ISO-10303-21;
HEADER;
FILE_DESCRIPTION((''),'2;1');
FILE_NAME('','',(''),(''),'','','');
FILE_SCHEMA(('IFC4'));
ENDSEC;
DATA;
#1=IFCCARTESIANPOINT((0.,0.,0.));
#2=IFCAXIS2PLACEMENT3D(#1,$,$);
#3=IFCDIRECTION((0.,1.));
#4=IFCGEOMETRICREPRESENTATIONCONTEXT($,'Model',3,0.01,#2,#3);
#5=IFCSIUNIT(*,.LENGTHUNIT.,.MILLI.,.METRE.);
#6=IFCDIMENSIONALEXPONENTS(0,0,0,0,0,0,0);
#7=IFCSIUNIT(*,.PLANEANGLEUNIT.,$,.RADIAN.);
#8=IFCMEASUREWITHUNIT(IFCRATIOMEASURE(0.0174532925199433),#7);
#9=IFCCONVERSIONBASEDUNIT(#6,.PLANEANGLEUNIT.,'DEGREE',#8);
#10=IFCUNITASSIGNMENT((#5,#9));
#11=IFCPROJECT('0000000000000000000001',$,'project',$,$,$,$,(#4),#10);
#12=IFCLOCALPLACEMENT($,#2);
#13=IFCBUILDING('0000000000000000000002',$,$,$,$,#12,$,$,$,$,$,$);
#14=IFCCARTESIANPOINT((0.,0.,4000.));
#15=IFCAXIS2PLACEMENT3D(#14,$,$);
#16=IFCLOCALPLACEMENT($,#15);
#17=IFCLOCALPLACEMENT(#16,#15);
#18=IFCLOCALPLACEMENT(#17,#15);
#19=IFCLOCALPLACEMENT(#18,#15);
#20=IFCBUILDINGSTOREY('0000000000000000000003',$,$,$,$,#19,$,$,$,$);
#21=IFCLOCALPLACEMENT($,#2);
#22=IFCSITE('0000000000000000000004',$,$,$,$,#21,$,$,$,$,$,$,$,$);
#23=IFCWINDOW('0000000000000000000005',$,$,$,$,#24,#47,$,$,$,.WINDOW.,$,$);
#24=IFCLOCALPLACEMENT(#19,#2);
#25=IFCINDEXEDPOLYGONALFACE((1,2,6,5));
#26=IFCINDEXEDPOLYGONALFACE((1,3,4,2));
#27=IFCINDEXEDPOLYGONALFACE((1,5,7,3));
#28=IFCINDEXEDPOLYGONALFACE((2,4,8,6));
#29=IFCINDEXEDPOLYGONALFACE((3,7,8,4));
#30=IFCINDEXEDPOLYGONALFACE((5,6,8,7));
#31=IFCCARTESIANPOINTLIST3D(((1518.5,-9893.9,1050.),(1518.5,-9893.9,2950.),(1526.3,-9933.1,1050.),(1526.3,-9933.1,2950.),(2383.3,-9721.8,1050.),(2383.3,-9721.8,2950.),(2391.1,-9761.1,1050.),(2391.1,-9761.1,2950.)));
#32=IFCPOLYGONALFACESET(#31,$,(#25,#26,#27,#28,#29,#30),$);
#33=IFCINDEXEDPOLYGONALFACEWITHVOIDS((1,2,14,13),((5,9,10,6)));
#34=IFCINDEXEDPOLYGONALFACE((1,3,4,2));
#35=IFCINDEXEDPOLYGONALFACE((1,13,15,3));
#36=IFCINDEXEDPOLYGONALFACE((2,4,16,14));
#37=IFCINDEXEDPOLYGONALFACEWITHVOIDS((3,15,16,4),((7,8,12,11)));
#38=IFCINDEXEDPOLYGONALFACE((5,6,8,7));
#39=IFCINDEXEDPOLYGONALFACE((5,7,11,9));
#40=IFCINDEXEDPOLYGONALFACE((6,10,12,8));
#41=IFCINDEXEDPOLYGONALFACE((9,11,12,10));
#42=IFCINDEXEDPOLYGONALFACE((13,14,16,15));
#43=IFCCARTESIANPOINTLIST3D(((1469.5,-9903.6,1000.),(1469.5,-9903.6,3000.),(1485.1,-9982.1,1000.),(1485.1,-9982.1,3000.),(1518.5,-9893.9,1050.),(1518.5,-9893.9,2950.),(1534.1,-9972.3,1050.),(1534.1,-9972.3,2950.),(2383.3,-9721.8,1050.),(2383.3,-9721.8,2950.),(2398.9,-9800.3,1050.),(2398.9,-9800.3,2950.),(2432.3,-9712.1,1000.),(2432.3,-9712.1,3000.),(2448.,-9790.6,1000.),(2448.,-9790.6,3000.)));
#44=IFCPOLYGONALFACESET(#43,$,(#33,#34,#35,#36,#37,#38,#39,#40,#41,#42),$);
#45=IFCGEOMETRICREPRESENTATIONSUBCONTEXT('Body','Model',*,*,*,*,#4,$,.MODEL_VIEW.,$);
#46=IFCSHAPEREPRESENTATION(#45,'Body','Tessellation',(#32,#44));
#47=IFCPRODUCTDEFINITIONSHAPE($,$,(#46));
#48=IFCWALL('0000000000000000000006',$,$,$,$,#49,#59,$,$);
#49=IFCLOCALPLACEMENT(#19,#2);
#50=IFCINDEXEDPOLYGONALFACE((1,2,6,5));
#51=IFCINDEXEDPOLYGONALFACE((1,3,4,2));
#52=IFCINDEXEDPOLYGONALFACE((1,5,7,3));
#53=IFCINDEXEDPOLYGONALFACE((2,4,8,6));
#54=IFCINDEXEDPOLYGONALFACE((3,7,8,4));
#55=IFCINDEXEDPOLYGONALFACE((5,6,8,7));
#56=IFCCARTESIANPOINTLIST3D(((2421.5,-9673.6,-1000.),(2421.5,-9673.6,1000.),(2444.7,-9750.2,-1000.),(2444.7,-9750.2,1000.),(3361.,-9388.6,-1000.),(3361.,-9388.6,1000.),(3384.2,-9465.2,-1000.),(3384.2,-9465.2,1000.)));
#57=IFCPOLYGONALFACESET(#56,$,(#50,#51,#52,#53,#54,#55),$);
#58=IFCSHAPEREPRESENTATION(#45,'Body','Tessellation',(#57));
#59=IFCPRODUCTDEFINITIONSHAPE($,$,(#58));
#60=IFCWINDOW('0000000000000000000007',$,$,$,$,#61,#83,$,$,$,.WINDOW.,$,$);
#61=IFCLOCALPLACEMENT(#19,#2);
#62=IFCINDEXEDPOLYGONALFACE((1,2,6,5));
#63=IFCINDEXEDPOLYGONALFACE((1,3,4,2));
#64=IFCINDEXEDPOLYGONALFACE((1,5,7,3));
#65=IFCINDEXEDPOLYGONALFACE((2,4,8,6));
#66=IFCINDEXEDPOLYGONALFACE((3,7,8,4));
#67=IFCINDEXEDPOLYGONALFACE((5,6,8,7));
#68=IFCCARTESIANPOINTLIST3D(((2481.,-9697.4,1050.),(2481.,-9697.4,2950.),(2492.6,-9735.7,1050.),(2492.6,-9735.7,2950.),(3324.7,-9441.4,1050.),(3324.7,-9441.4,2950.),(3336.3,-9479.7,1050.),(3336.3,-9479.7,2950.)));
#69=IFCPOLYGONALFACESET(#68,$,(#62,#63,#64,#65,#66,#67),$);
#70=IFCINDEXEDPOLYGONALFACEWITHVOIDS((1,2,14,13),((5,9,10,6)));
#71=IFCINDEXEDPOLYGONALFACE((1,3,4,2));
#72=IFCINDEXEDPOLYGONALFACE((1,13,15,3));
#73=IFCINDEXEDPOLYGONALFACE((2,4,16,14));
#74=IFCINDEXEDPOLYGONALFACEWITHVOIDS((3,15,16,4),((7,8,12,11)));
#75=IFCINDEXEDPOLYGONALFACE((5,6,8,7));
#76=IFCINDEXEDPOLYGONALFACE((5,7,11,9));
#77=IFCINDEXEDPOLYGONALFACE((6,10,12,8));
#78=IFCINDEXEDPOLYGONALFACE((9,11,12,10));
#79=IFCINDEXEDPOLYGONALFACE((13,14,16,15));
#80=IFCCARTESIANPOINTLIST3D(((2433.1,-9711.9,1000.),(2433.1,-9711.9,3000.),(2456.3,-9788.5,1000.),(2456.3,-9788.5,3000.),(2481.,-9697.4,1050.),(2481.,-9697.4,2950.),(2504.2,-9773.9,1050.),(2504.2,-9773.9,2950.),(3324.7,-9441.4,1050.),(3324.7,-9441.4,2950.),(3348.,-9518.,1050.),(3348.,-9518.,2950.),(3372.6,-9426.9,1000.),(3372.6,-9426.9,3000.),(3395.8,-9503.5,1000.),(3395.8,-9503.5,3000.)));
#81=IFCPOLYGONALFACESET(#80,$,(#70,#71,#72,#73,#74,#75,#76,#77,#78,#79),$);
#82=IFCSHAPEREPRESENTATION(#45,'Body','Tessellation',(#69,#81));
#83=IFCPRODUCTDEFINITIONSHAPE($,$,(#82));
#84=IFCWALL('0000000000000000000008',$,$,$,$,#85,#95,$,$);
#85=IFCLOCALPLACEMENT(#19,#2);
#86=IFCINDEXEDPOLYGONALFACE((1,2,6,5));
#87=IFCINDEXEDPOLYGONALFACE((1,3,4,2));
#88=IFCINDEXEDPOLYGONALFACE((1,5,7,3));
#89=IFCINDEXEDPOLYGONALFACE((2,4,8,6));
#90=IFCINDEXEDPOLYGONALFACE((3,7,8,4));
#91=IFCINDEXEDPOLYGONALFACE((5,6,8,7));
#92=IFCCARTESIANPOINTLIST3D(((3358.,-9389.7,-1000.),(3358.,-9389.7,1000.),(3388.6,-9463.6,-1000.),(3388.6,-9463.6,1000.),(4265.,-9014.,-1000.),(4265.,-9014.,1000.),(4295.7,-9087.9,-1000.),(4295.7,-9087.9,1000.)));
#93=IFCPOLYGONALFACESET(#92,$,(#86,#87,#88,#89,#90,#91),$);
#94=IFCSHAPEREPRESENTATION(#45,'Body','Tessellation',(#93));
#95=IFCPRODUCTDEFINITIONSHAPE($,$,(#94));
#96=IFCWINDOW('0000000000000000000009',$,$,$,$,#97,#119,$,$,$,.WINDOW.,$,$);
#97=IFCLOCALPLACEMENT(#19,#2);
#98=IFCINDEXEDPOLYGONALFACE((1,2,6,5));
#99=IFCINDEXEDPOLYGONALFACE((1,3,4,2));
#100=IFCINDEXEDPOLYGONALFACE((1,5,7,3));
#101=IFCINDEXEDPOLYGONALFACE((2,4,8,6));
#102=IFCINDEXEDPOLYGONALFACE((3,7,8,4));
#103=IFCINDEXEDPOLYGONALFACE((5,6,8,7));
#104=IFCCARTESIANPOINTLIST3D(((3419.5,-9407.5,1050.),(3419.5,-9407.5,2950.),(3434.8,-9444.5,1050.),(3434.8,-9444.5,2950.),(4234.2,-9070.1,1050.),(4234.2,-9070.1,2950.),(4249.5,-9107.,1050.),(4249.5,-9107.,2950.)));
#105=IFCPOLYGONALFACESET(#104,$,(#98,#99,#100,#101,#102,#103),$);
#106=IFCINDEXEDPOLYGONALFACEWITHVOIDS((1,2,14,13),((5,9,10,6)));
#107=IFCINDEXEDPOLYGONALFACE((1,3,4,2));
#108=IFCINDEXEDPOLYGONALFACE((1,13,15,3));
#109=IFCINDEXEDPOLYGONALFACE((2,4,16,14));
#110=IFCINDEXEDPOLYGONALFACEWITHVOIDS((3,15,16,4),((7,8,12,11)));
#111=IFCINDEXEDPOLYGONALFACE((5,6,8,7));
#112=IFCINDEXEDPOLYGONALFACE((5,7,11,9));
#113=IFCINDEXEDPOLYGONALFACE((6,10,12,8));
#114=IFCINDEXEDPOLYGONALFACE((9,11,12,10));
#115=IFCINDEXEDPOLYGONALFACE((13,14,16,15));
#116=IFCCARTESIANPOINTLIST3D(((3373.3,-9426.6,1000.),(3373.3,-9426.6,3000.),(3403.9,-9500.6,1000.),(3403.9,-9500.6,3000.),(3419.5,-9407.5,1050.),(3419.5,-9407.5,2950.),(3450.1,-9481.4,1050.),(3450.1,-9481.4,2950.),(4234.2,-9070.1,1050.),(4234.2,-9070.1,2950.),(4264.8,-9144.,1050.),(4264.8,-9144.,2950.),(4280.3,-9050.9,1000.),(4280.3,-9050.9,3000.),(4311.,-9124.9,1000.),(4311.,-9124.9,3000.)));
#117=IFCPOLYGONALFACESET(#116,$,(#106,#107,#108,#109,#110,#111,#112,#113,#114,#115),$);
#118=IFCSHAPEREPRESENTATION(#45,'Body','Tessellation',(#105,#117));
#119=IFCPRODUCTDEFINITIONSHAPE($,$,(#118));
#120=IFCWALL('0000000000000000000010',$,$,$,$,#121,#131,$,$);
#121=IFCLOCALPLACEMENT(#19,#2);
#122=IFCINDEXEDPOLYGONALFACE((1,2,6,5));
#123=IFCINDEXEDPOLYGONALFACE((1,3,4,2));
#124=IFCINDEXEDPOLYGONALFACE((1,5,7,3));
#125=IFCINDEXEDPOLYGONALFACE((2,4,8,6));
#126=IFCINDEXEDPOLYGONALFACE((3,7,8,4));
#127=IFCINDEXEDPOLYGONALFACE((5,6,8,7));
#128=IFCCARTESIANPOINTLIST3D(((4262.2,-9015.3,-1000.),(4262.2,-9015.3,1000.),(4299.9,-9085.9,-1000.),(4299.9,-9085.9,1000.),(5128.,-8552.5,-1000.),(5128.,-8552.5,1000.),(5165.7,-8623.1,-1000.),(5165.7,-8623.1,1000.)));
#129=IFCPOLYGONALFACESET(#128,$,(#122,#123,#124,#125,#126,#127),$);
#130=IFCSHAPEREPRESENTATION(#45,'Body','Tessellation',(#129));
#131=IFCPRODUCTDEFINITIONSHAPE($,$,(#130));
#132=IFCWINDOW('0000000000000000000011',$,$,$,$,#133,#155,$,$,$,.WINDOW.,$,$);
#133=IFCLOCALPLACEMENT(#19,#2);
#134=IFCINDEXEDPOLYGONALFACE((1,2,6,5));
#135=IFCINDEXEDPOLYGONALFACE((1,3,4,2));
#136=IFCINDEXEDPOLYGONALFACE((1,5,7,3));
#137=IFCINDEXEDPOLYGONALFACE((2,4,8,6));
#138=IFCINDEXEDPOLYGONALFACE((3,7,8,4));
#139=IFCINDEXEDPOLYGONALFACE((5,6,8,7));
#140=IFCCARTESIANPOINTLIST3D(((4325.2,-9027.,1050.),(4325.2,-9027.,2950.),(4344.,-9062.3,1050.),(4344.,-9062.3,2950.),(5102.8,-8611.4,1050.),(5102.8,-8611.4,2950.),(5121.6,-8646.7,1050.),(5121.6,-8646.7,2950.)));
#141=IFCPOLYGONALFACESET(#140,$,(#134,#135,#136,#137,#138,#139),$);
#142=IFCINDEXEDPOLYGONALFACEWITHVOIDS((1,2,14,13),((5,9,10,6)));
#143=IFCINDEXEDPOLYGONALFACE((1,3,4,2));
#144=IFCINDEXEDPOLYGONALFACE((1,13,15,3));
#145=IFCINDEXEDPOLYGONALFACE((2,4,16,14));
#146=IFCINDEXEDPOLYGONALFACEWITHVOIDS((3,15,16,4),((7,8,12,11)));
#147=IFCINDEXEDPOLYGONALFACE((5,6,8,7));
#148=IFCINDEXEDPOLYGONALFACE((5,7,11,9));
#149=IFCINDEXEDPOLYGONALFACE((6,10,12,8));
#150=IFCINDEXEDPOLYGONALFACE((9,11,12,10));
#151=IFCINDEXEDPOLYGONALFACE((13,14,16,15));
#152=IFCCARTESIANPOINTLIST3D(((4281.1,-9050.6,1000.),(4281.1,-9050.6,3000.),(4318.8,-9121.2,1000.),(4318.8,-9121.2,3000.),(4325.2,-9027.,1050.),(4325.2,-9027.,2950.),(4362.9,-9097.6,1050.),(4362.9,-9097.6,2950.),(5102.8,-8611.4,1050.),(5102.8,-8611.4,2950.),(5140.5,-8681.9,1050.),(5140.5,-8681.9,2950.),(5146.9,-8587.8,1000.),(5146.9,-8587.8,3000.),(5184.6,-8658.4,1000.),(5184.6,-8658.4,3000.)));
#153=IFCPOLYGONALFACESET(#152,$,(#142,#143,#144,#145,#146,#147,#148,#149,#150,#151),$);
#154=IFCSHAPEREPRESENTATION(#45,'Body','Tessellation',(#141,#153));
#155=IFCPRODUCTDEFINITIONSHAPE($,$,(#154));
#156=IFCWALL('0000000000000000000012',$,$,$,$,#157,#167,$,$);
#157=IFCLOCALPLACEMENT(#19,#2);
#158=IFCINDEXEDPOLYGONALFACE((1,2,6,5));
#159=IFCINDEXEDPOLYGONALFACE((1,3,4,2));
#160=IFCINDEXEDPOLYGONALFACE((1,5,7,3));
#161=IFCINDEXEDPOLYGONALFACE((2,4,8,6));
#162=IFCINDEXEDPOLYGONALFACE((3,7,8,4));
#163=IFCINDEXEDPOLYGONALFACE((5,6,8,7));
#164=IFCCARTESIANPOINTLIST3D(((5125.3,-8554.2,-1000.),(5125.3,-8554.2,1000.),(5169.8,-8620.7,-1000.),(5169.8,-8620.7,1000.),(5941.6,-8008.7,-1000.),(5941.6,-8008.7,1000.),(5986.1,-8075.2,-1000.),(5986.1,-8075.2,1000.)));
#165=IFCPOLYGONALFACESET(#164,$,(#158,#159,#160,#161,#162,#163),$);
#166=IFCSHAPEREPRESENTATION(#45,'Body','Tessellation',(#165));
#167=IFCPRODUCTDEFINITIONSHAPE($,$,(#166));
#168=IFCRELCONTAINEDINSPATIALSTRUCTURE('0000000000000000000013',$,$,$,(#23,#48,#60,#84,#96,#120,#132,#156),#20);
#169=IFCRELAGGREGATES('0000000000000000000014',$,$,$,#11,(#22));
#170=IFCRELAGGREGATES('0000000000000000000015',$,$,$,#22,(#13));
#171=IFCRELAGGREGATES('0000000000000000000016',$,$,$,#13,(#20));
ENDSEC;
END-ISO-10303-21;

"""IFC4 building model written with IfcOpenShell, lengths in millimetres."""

from ifc_helpers import new_model, entity, si_unit, converted_unit, direction, frame, origin, origin_2d, place, context, subcontext, project, spatial, rectangle, extrude, element, save


model = new_model("IFC4")

# Units and contexts
model_context = context("Model", 3, precision=0.01, world=origin(), true_north=direction((0.0, 1.0)))
body_context = subcontext(model_context, "Body", "Model", "MODEL_VIEW")
ifc_project = project(units=[si_unit("LENGTHUNIT", "METRE", prefix="MILLI"), converted_unit("PLANEANGLEUNIT", "DEGREE", entity("IfcRatioMeasure", 0.0174532925199433), si_unit("PLANEANGLEUNIT", "RADIAN"), dimensions=[0, 0, 0, 0, 0, 0, 0])], contexts=[model_context])

# Site, building, storey
site_placement = place(None, origin())
site = spatial("IfcSite", under=ifc_project, at=site_placement)
building_placement = place(None, origin())
building = spatial("IfcBuilding", under=site, at=building_placement)
placement_1 = place(None, frame((0.0, 0.0, 4000.0)))
placement_2 = place(placement_1, frame((0.0, 0.0, 4000.0)))
placement_3 = place(placement_2, frame((0.0, 0.0, 4000.0)))
storey_placement = place(placement_3, frame((0.0, 0.0, 4000.0)))
storey = spatial("IfcBuildingStorey", under=building, at=storey_placement)

# Shared definitions
cartesian_point_1 = entity("IfcCartesianPoint", [-440.9, -950.0])
shared_polyline = entity("IfcPolyline", [cartesian_point_1, entity("IfcCartesianPoint", [-440.9, 950.0]), entity("IfcCartesianPoint", [-440.9, 950.0]), entity("IfcCartesianPoint", [440.9, 950.0]), entity("IfcCartesianPoint", [440.9, 950.0]), entity("IfcCartesianPoint", [440.9, -950.0]), entity("IfcCartesianPoint", [440.9, -950.0]), entity("IfcCartesianPoint", [-440.9, -950.0]), cartesian_point_1])

# Window
window_1_placement = place(storey_placement, frame((1950.9, -9807.9, 2000.0), z_axis=(0.0, 0.0, 1.0), x_axis=(9807.852625, 1950.904121, 0.0)))
cartesian_point_2 = entity("IfcCartesianPoint", [-490.9, -1000.0])
element("IfcWindow", 1, at=window_1_placement, inside=storey, PredefinedType="WINDOW", context=body_context, shape_type="SweptSolid", body=[
    entity("IfcExtrudedAreaSolid", entity("IfcArbitraryClosedProfileDef", "AREA", None, shared_polyline), entity("IfcAxis2Placement3D", entity("IfcCartesianPoint", [0.0, 0.0, 0.0]), entity("IfcDirection", [0.0, -1.0, 0.0]), entity("IfcDirection", [1.0, 0.0, 0.0])), entity("IfcDirection", [0.0, 0.0, 1.0]), 40.0),
    entity("IfcExtrudedAreaSolid", entity("IfcArbitraryProfileDefWithVoids", "AREA", None, entity("IfcPolyline", [cartesian_point_2, entity("IfcCartesianPoint", [-490.9, 1000.0]), entity("IfcCartesianPoint", [-490.9, 1000.0]), entity("IfcCartesianPoint", [490.9, 1000.0]), entity("IfcCartesianPoint", [490.9, 1000.0]), entity("IfcCartesianPoint", [490.9, -1000.0]), entity("IfcCartesianPoint", [490.9, -1000.0]), entity("IfcCartesianPoint", [-490.9, -1000.0]), cartesian_point_2]), [shared_polyline]), entity("IfcAxis2Placement3D", entity("IfcCartesianPoint", [0.0, 0.0, 0.0]), entity("IfcDirection", [0.0, -1.0, 0.0]), entity("IfcDirection", [1.0, 0.0, 0.0])), entity("IfcDirection", [0.0, 0.0, 1.0]), 80.0),
])

# Wall
wall_1_placement = place(storey_placement, frame((2902.8, -9569.4, -1000.0), z_axis=(0.0, 0.0, 1.0), x_axis=(9569.403667, 2902.845753, 0.0)))
element("IfcWall", 2, at=wall_1_placement, inside=storey, context=body_context, shape_type="SweptSolid", body=[
    extrude(rectangle(XDim=981.7, YDim=80.0, at=origin_2d()), origin(), (0.0, 0.0, 1.0), 2000.0),
])

# Window
window_2_placement = place(storey_placement, frame((2902.8, -9569.4, 2000.0), z_axis=(0.0, 0.0, 1.0), x_axis=(9569.403667, 2902.845753, 0.0)))
cartesian_point_3 = entity("IfcCartesianPoint", [-490.9, -1000.0])
element("IfcWindow", 3, at=window_2_placement, inside=storey, PredefinedType="WINDOW", context=body_context, shape_type="SweptSolid", body=[
    entity("IfcExtrudedAreaSolid", entity("IfcArbitraryClosedProfileDef", "AREA", None, shared_polyline), entity("IfcAxis2Placement3D", entity("IfcCartesianPoint", [0.0, 0.0, 0.0]), entity("IfcDirection", [0.0, -1.0, 0.0]), entity("IfcDirection", [1.0, 0.0, 0.0])), entity("IfcDirection", [0.0, 0.0, 1.0]), 40.0),
    entity("IfcExtrudedAreaSolid", entity("IfcArbitraryProfileDefWithVoids", "AREA", None, entity("IfcPolyline", [cartesian_point_3, entity("IfcCartesianPoint", [-490.9, 1000.0]), entity("IfcCartesianPoint", [-490.9, 1000.0]), entity("IfcCartesianPoint", [490.9, 1000.0]), entity("IfcCartesianPoint", [490.9, 1000.0]), entity("IfcCartesianPoint", [490.9, -1000.0]), entity("IfcCartesianPoint", [490.9, -1000.0]), entity("IfcCartesianPoint", [-490.9, -1000.0]), cartesian_point_3]), [shared_polyline]), entity("IfcAxis2Placement3D", entity("IfcCartesianPoint", [0.0, 0.0, 0.0]), entity("IfcDirection", [0.0, -1.0, 0.0]), entity("IfcDirection", [1.0, 0.0, 0.0])), entity("IfcDirection", [0.0, 0.0, 1.0]), 80.0),
])

# Wall
wall_2_placement = place(storey_placement, frame((3826.8, -9238.8, -1000.0), z_axis=(0.0, 0.0, 1.0), x_axis=(9238.794667, 3826.835911, 0.0)))
element("IfcWall", 4, at=wall_2_placement, inside=storey, context=body_context, shape_type="SweptSolid", body=[
    extrude(rectangle(XDim=981.7, YDim=80.0, at=origin_2d()), origin(), (0.0, 0.0, 1.0), 2000.0),
])

# Window
window_3_placement = place(storey_placement, frame((3826.8, -9238.8, 2000.0), z_axis=(0.0, 0.0, 1.0), x_axis=(9238.794667, 3826.835911, 0.0)))
cartesian_point_4 = entity("IfcCartesianPoint", [-490.9, -1000.0])
element("IfcWindow", 5, at=window_3_placement, inside=storey, PredefinedType="WINDOW", context=body_context, shape_type="SweptSolid", body=[
    entity("IfcExtrudedAreaSolid", entity("IfcArbitraryClosedProfileDef", "AREA", None, shared_polyline), entity("IfcAxis2Placement3D", entity("IfcCartesianPoint", [0.0, 0.0, 0.0]), entity("IfcDirection", [0.0, -1.0, 0.0]), entity("IfcDirection", [1.0, 0.0, 0.0])), entity("IfcDirection", [0.0, 0.0, 1.0]), 40.0),
    entity("IfcExtrudedAreaSolid", entity("IfcArbitraryProfileDefWithVoids", "AREA", None, entity("IfcPolyline", [cartesian_point_4, entity("IfcCartesianPoint", [-490.9, 1000.0]), entity("IfcCartesianPoint", [-490.9, 1000.0]), entity("IfcCartesianPoint", [490.9, 1000.0]), entity("IfcCartesianPoint", [490.9, 1000.0]), entity("IfcCartesianPoint", [490.9, -1000.0]), entity("IfcCartesianPoint", [490.9, -1000.0]), entity("IfcCartesianPoint", [-490.9, -1000.0]), cartesian_point_4]), [shared_polyline]), entity("IfcAxis2Placement3D", entity("IfcCartesianPoint", [0.0, 0.0, 0.0]), entity("IfcDirection", [0.0, -1.0, 0.0]), entity("IfcDirection", [1.0, 0.0, 0.0])), entity("IfcDirection", [0.0, 0.0, 1.0]), 80.0),
])

# Wall
wall_3_placement = place(storey_placement, frame((4714.0, -8819.2, -1000.0), z_axis=(0.0, 0.0, 1.0), x_axis=(8819.212769, 4713.967134, 0.0)))
element("IfcWall", 6, at=wall_3_placement, inside=storey, context=body_context, shape_type="SweptSolid", body=[
    extrude(rectangle(XDim=981.7, YDim=80.0, at=origin_2d()), origin(), (0.0, 0.0, 1.0), 2000.0),
])

# Window
window_4_placement = place(storey_placement, frame((4714.0, -8819.2, 2000.0), z_axis=(0.0, 0.0, 1.0), x_axis=(8819.212769, 4713.967134, 0.0)))
cartesian_point_5 = entity("IfcCartesianPoint", [-490.9, -1000.0])
element("IfcWindow", 7, at=window_4_placement, inside=storey, PredefinedType="WINDOW", context=body_context, shape_type="SweptSolid", body=[
    entity("IfcExtrudedAreaSolid", entity("IfcArbitraryClosedProfileDef", "AREA", None, shared_polyline), entity("IfcAxis2Placement3D", entity("IfcCartesianPoint", [0.0, 0.0, 0.0]), entity("IfcDirection", [0.0, -1.0, 0.0]), entity("IfcDirection", [1.0, 0.0, 0.0])), entity("IfcDirection", [0.0, 0.0, 1.0]), 40.0),
    entity("IfcExtrudedAreaSolid", entity("IfcArbitraryProfileDefWithVoids", "AREA", None, entity("IfcPolyline", [cartesian_point_5, entity("IfcCartesianPoint", [-490.9, 1000.0]), entity("IfcCartesianPoint", [-490.9, 1000.0]), entity("IfcCartesianPoint", [490.9, 1000.0]), entity("IfcCartesianPoint", [490.9, 1000.0]), entity("IfcCartesianPoint", [490.9, -1000.0]), entity("IfcCartesianPoint", [490.9, -1000.0]), entity("IfcCartesianPoint", [-490.9, -1000.0]), cartesian_point_5]), [shared_polyline]), entity("IfcAxis2Placement3D", entity("IfcCartesianPoint", [0.0, 0.0, 0.0]), entity("IfcDirection", [0.0, -1.0, 0.0]), entity("IfcDirection", [1.0, 0.0, 0.0])), entity("IfcDirection", [0.0, 0.0, 1.0]), 80.0),
])

# Wall
wall_4_placement = place(storey_placement, frame((5555.7, -8314.7, -1000.0), z_axis=(0.0, 0.0, 1.0), x_axis=(8314.697373, 5555.700459, 0.0)))
element("IfcWall", 8, at=wall_4_placement, inside=storey, context=body_context, shape_type="SweptSolid", body=[
    extrude(rectangle(XDim=981.7, YDim=80.0, at=origin_2d()), origin(), (0.0, 0.0, 1.0), 2000.0),
])

save(model, "model.ifc")
